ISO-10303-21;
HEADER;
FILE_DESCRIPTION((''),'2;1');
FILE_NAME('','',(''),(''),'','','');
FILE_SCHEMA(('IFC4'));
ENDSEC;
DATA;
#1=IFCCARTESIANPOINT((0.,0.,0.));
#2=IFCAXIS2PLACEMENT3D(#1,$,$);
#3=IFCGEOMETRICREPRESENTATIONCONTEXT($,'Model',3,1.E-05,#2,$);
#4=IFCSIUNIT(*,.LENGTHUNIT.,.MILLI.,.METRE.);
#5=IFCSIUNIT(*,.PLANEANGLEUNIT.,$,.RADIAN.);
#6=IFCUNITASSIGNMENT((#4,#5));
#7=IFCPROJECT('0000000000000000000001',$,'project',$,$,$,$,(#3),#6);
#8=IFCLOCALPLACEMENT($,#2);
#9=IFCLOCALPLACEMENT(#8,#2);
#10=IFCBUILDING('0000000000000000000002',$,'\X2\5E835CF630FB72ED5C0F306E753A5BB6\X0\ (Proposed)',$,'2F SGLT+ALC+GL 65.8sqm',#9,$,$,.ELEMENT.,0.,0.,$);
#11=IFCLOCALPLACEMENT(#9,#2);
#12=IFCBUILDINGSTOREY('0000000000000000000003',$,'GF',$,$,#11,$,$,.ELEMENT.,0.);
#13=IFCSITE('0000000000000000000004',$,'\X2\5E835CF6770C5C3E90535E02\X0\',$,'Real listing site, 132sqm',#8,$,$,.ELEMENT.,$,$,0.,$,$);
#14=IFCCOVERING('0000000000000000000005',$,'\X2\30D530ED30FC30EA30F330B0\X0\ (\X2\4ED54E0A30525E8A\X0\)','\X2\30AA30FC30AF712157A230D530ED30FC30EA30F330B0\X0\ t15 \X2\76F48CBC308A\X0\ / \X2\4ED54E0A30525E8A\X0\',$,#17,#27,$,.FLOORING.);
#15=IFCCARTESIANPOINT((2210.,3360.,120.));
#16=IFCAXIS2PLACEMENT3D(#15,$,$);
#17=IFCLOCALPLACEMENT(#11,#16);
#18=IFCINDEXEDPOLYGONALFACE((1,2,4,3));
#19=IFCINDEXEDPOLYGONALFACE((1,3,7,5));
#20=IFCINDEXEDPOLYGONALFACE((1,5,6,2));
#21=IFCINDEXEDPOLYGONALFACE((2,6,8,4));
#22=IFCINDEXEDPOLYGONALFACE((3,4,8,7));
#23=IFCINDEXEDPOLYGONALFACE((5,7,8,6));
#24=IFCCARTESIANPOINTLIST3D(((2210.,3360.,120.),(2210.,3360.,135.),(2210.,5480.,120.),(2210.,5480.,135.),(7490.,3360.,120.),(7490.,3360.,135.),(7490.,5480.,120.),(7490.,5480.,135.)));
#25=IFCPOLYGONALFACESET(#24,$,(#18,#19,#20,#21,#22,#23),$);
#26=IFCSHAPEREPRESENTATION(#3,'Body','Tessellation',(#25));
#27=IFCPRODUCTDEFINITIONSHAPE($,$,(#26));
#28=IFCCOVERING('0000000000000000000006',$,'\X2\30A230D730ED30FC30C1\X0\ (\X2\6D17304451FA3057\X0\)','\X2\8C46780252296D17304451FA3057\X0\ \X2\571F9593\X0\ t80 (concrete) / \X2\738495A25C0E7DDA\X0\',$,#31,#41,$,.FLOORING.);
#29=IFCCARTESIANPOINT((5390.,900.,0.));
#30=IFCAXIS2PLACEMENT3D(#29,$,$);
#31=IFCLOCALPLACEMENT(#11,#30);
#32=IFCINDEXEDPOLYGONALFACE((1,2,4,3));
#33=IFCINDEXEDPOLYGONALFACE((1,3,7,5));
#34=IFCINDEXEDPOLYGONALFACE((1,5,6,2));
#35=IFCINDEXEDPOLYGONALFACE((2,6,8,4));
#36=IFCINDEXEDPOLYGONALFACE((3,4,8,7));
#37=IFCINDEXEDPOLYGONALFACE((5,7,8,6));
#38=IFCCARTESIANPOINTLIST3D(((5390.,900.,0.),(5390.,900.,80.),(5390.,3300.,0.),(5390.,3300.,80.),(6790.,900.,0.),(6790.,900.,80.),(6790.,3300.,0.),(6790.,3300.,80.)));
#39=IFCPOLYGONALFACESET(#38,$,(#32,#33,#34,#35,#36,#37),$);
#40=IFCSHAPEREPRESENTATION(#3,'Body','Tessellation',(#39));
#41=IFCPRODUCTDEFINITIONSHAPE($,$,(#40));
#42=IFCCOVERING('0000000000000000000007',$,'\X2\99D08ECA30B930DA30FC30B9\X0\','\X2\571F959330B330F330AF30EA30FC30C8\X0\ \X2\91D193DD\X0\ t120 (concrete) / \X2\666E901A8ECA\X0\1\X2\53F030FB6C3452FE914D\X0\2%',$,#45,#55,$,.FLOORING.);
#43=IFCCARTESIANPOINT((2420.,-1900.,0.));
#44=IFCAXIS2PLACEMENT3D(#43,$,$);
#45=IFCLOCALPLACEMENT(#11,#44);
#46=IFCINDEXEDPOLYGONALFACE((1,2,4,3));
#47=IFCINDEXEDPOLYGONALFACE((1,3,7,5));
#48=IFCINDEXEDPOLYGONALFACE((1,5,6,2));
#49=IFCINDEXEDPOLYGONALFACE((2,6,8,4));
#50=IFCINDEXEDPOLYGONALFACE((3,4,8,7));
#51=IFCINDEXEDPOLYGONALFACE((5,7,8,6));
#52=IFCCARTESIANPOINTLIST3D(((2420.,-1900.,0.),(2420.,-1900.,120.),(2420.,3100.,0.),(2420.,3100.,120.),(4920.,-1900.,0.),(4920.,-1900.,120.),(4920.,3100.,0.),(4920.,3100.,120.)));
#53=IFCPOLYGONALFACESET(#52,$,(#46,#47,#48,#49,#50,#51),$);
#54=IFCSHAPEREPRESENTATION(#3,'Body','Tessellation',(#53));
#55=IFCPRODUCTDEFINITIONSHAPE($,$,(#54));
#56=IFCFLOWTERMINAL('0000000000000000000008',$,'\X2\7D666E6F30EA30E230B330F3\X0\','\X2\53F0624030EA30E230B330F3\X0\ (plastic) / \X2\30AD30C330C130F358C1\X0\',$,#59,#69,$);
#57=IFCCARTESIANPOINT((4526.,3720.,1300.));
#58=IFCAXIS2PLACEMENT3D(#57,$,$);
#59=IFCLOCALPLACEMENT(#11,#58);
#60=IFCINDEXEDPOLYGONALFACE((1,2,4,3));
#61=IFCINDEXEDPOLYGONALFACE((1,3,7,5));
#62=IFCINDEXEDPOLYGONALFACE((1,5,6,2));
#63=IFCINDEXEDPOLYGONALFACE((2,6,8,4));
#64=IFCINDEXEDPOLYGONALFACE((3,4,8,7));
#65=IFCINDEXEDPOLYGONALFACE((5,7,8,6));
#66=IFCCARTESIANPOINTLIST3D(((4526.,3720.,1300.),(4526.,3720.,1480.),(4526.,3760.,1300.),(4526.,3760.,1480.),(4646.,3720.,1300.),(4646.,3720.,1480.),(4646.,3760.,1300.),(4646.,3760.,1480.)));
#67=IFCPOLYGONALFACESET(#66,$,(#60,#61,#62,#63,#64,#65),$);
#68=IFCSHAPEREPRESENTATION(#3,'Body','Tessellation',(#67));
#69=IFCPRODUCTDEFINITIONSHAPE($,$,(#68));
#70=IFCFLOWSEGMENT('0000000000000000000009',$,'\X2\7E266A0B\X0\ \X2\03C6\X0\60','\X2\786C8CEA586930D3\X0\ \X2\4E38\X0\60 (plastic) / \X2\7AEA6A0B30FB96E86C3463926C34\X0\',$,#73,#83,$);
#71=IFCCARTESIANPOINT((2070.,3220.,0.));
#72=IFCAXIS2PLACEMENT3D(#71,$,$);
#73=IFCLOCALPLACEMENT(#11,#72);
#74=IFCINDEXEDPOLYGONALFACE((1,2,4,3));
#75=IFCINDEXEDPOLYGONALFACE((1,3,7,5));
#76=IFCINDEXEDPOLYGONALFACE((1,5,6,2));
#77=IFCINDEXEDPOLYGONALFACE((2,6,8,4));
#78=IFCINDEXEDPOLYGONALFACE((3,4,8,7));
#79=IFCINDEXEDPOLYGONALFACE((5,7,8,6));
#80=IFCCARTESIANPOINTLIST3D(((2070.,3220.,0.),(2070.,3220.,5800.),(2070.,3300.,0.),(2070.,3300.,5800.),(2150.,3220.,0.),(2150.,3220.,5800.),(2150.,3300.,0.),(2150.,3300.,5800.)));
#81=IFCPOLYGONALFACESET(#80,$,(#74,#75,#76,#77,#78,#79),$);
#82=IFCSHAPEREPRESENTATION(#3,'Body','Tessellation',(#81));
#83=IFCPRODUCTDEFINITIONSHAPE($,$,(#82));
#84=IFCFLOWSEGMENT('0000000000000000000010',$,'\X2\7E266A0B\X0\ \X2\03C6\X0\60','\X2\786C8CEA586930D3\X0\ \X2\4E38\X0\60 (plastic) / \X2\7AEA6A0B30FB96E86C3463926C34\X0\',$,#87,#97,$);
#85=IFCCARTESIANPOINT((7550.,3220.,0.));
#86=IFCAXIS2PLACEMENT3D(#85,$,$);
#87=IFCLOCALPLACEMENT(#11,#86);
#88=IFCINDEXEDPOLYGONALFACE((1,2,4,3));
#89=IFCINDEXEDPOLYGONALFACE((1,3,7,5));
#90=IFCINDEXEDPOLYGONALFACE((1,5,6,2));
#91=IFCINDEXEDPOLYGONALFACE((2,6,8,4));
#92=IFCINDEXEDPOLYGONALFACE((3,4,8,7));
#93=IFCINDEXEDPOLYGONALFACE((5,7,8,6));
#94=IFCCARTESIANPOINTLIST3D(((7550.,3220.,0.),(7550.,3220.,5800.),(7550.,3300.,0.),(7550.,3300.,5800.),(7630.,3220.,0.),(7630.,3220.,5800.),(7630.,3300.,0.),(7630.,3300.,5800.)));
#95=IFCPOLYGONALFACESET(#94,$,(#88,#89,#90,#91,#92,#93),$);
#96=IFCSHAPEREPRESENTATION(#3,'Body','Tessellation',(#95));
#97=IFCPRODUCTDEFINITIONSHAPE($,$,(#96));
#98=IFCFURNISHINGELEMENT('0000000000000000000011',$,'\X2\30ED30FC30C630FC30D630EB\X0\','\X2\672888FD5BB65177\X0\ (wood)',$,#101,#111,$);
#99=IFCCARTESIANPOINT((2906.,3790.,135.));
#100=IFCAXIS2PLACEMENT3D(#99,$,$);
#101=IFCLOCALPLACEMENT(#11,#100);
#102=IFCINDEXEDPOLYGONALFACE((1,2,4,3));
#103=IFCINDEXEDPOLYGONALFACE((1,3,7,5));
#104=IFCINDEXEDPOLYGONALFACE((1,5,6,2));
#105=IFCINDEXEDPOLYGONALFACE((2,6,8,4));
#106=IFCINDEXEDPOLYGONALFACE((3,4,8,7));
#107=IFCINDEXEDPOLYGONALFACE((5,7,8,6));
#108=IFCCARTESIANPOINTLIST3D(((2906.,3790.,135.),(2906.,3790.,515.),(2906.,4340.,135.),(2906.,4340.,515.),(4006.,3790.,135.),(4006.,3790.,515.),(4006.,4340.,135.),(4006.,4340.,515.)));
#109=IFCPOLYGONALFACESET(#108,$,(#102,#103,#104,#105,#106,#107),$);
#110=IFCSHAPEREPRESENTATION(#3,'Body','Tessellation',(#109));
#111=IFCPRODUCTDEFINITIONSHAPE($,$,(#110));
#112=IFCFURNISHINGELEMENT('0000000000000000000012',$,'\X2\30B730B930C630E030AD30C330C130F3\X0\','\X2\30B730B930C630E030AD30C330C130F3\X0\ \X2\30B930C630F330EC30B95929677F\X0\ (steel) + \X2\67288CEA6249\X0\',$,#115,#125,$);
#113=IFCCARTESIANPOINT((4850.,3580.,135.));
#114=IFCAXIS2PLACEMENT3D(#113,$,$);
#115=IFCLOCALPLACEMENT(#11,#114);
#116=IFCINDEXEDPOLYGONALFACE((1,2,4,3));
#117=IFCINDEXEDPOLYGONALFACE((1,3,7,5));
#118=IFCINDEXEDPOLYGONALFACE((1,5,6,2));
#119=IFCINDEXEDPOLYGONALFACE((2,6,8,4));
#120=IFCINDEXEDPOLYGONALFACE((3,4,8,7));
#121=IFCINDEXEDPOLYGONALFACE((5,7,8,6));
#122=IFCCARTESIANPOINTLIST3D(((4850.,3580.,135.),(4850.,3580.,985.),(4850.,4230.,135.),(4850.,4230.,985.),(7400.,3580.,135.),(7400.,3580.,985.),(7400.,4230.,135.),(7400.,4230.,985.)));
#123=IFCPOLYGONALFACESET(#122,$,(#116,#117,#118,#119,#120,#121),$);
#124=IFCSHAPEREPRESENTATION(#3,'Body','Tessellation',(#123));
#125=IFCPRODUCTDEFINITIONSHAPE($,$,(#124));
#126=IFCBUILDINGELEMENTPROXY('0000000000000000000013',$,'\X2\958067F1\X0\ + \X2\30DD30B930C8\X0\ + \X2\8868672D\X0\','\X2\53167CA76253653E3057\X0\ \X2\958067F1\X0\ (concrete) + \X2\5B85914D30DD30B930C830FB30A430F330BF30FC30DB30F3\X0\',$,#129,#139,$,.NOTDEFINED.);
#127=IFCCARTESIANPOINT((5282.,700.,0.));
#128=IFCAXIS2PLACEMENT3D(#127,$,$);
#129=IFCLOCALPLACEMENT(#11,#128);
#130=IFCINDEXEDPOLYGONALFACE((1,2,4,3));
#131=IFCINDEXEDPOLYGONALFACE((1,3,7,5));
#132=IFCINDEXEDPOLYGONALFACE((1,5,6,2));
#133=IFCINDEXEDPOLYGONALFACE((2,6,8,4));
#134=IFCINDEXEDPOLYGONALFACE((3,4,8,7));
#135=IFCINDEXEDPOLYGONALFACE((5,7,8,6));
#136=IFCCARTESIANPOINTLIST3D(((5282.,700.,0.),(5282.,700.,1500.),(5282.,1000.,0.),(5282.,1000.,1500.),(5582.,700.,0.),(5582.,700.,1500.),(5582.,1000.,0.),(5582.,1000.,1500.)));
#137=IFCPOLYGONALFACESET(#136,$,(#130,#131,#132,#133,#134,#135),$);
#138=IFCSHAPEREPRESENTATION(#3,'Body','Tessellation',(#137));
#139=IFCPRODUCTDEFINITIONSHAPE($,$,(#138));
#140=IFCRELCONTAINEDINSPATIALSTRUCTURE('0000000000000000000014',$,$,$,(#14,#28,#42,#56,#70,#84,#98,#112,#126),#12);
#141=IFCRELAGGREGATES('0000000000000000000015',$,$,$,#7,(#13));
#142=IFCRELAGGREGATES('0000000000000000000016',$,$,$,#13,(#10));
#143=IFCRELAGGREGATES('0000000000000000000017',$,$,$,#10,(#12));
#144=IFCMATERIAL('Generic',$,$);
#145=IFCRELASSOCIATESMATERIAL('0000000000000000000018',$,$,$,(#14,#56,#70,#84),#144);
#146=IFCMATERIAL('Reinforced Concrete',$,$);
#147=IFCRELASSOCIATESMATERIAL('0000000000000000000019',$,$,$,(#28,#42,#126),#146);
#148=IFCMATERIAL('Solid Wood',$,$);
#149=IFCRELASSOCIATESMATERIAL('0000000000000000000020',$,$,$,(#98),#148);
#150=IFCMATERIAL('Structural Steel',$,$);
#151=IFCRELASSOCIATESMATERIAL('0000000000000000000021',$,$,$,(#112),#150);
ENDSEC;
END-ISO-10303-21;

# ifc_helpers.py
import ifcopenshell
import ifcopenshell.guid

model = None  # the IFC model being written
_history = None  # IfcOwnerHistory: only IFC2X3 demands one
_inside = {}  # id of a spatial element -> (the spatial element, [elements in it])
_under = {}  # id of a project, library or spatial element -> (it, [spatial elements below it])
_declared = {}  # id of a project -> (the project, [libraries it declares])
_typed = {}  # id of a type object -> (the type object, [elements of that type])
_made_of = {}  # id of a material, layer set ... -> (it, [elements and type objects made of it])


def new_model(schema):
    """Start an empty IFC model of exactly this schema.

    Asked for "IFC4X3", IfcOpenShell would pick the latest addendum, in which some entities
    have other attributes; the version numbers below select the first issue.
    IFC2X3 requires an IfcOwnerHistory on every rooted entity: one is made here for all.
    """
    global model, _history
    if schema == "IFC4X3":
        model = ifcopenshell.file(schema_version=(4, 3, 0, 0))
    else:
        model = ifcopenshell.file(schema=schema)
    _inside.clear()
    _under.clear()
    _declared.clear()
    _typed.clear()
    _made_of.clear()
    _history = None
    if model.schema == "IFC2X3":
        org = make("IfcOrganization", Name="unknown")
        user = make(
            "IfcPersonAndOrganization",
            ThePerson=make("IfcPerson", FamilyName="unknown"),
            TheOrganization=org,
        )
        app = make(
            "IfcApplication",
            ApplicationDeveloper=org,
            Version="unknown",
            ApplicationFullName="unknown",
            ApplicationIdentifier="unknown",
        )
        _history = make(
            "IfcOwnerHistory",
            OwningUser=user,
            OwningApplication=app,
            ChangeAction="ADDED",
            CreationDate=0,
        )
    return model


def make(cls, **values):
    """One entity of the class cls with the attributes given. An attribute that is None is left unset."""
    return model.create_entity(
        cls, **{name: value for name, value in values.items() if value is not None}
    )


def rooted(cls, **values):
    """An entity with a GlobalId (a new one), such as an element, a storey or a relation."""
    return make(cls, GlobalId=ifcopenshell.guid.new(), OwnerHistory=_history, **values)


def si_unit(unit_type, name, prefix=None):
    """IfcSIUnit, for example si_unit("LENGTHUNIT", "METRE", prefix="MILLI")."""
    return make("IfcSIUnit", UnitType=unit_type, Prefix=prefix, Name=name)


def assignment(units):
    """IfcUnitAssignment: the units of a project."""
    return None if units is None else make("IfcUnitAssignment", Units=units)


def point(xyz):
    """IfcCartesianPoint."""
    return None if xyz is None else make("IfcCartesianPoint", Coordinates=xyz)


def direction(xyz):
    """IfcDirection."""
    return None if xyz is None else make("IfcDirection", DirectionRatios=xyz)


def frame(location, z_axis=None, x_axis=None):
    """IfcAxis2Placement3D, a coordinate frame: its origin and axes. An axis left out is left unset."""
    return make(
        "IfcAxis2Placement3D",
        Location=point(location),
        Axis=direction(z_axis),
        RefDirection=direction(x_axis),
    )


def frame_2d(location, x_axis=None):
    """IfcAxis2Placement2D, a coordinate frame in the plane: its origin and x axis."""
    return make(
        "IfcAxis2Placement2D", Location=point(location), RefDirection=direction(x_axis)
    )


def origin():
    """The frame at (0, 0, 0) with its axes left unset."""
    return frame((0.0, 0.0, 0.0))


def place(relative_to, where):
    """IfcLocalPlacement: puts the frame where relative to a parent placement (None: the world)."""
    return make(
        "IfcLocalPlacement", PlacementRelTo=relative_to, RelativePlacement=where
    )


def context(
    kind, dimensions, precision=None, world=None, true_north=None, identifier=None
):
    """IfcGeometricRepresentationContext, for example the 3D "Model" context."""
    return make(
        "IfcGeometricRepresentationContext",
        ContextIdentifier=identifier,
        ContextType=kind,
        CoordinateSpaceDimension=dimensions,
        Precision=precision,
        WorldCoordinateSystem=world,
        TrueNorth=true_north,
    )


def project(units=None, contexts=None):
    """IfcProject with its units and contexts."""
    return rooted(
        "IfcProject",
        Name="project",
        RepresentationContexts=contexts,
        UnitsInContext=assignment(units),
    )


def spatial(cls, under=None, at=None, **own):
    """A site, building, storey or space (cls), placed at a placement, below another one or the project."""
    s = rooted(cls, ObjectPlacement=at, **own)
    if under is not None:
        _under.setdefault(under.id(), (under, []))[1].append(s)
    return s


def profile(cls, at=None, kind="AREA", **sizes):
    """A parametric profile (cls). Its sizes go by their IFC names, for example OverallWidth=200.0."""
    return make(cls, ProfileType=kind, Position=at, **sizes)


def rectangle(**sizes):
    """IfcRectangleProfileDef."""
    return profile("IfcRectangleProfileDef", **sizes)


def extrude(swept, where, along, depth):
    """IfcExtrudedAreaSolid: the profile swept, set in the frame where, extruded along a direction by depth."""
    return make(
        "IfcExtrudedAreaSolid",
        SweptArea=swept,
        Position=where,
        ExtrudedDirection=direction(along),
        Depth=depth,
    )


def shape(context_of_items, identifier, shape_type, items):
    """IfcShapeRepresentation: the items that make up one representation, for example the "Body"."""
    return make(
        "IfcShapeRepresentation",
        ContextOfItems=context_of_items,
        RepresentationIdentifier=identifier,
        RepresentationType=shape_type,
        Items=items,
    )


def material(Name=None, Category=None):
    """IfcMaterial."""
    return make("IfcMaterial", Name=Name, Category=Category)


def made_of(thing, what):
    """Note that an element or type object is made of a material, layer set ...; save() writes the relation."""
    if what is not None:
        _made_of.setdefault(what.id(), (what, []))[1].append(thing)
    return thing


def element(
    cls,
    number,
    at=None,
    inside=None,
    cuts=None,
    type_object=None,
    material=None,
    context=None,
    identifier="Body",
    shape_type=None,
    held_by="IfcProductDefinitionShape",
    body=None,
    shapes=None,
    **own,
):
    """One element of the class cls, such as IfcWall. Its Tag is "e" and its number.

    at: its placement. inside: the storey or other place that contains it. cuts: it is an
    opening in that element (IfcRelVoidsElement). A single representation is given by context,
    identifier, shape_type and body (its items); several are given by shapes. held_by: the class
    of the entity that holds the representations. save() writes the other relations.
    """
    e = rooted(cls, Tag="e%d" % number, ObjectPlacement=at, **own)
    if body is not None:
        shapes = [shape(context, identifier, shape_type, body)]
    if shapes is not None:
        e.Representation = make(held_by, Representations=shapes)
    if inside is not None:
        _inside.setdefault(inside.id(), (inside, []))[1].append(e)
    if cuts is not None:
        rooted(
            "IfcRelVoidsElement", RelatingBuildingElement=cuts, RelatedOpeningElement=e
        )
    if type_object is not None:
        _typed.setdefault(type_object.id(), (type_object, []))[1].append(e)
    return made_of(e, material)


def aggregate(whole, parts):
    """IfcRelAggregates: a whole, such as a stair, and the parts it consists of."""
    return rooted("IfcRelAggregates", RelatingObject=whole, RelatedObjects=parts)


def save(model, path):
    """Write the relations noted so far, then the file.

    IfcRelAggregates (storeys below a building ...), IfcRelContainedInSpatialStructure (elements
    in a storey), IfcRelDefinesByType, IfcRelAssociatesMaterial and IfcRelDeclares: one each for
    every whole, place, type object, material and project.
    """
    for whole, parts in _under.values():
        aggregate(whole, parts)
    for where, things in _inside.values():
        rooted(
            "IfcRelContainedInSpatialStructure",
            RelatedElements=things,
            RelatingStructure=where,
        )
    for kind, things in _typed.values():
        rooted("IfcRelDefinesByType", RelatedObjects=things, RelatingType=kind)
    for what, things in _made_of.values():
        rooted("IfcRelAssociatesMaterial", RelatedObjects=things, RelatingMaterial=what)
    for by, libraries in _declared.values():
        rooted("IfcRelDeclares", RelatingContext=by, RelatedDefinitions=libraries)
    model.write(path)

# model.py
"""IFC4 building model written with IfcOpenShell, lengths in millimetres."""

from ifc_helpers import new_model, si_unit, frame, frame_2d, origin, place, context, project, spatial, rectangle, extrude, material, element, save


model = new_model("IFC4")

# Units and contexts
model_context = context("Model", 3, precision=1e-05, world=origin())
ifc_project = project(units=[si_unit("LENGTHUNIT", "METRE", prefix="MILLI"), si_unit("PLANEANGLEUNIT", "RADIAN")], contexts=[model_context])

# Site, building, storey
site_placement = place(None, origin())
site = spatial("IfcSite", under=ifc_project, at=site_placement, Name="広島県尾道市", ObjectType="Real listing site, 132sqm", CompositionType="ELEMENT", RefElevation=0.0)
building_placement = place(site_placement, origin())
building = spatial("IfcBuilding", under=site, at=building_placement, Name="広島・狭小の町家 (Proposed)", ObjectType="2F SGLT+ALC+GL 65.8sqm", CompositionType="ELEMENT", ElevationOfRefHeight=0.0, ElevationOfTerrain=0.0)
storey_placement = place(building_placement, origin())
storey = spatial("IfcBuildingStorey", under=building, at=storey_placement, Name="GF", CompositionType="ELEMENT", Elevation=0.0)

# Shared definitions
ifc_material_1 = material(Name="Solid Wood")

# Shared definitions
ifc_material_2 = material(Name="Reinforced Concrete")

# Coverings
ifc_material_3 = material(Name="Generic")
covering_1_placement = place(storey_placement, frame((2210.0, 3360.0, 120.0)))
element("IfcCovering", 1, at=covering_1_placement, inside=storey, material=ifc_material_3, Name="フローリング (仕上げ床)", Description="オーク無垢フローリング t15 直貼り / 仕上げ床", PredefinedType="FLOORING", context=model_context, shape_type="SweptSolid", body=[
    extrude(rectangle(XDim=5280.0, YDim=2120.0, at=frame_2d((2640.0, 1060.0))), frame((2210.0, 3360.0, 120.0)), (0.0, 0.0, 1.0), 15.0),
])
covering_2_placement = place(storey_placement, frame((5390.0, 900.0, 0.0)))
element("IfcCovering", 2, at=covering_2_placement, inside=storey, material=ifc_material_2, Name="アプローチ (洗い出し)", Description="豆砂利洗い出し 土間 t80 (concrete) / 玄関導線", PredefinedType="FLOORING", context=model_context, shape_type="SweptSolid", body=[
    extrude(rectangle(XDim=1400.0, YDim=2400.0, at=frame_2d((700.0, 1200.0))), frame((5390.0, 900.0, 0.0)), (0.0, 0.0, 1.0), 80.0),
])
covering_3_placement = place(storey_placement, frame((2420.0, -1900.0, 0.0)))
element("IfcCovering", 3, at=covering_3_placement, inside=storey, material=ifc_material_2, Name="駐車スペース", Description="土間コンクリート 金鏝 t120 (concrete) / 普通車1台・水勾配2%", PredefinedType="FLOORING", context=model_context, shape_type="SweptSolid", body=[
    extrude(rectangle(XDim=2500.0, YDim=5000.0, at=frame_2d((1250.0, 2500.0))), frame((2420.0, -1900.0, 0.0)), (0.0, 0.0, 1.0), 120.0),
])

# Flow terminal
flow_terminal_placement = place(storey_placement, frame((4526.0, 3720.0, 1300.0)))
element("IfcFlowTerminal", 4, at=flow_terminal_placement, inside=storey, material=ifc_material_3, Name="給湯リモコン", Description="台所リモコン (plastic) / キッチン壁", context=model_context, shape_type="SweptSolid", body=[
    extrude(rectangle(XDim=120.0, YDim=40.0, at=frame_2d((60.0, 20.0))), frame((4526.0, 3720.0, 1300.0)), (0.0, 0.0, 1.0), 180.0),
])

# Flow segments
flow_segment_1_placement = place(storey_placement, frame((2070.0, 3220.0, 0.0)))
element("IfcFlowSegment", 5, at=flow_segment_1_placement, inside=storey, material=ifc_material_3, Name="縦樋 φ60", Description="硬質塩ビ 丸60 (plastic) / 竪樋・雨水排水", context=model_context, shape_type="SweptSolid", body=[
    extrude(rectangle(XDim=80.0, YDim=80.0, at=frame_2d((40.0, 40.0))), frame((2070.0, 3220.0, 0.0)), (0.0, 0.0, 1.0), 5800.0),
])
flow_segment_2_placement = place(storey_placement, frame((7550.0, 3220.0, 0.0)))
element("IfcFlowSegment", 6, at=flow_segment_2_placement, inside=storey, material=ifc_material_3, Name="縦樋 φ60", Description="硬質塩ビ 丸60 (plastic) / 竪樋・雨水排水", context=model_context, shape_type="SweptSolid", body=[
    extrude(rectangle(XDim=80.0, YDim=80.0, at=frame_2d((40.0, 40.0))), frame((7550.0, 3220.0, 0.0)), (0.0, 0.0, 1.0), 5800.0),
])

# Furnishing elements
furnishing_1_placement = place(storey_placement, frame((2906.0, 3790.0, 135.0)))
element("IfcFurnishingElement", 7, at=furnishing_1_placement, inside=storey, material=ifc_material_1, Name="ローテーブル", Description="木製家具 (wood)", context=model_context, shape_type="SweptSolid", body=[
    extrude(rectangle(XDim=1100.0, YDim=550.0, at=frame_2d((550.0, 275.0))), frame((2906.0, 3790.0, 135.0)), (0.0, 0.0, 1.0), 380.0),
])
ifc_material_4 = material(Name="Structural Steel")
furnishing_2_placement = place(storey_placement, frame((4850.0, 3580.0, 135.0)))
element("IfcFurnishingElement", 8, at=furnishing_2_placement, inside=storey, material=ifc_material_4, Name="システムキッチン", Description="システムキッチン ステンレス天板 (steel) + 木質扉", context=model_context, shape_type="SweptSolid", body=[
    extrude(rectangle(XDim=2550.0, YDim=650.0, at=frame_2d((1275.0, 325.0))), frame((4850.0, 3580.0, 135.0)), (0.0, 0.0, 1.0), 850.0),
])

# Building element proxy
proxy_placement = place(storey_placement, frame((5282.0, 700.0, 0.0)))
element("IfcBuildingElementProxy", 9, at=proxy_placement, inside=storey, material=ifc_material_2, Name="門柱 + ポスト + 表札", Description="化粧打放し 門柱 (concrete) + 宅配ポスト・インターホン", PredefinedType="NOTDEFINED", context=model_context, shape_type="SweptSolid", body=[
    extrude(rectangle(XDim=300.0, YDim=300.0, at=frame_2d((150.0, 150.0))), frame((5282.0, 700.0, 0.0)), (0.0, 0.0, 1.0), 1500.0),
])

save(model, "model.ifc")
